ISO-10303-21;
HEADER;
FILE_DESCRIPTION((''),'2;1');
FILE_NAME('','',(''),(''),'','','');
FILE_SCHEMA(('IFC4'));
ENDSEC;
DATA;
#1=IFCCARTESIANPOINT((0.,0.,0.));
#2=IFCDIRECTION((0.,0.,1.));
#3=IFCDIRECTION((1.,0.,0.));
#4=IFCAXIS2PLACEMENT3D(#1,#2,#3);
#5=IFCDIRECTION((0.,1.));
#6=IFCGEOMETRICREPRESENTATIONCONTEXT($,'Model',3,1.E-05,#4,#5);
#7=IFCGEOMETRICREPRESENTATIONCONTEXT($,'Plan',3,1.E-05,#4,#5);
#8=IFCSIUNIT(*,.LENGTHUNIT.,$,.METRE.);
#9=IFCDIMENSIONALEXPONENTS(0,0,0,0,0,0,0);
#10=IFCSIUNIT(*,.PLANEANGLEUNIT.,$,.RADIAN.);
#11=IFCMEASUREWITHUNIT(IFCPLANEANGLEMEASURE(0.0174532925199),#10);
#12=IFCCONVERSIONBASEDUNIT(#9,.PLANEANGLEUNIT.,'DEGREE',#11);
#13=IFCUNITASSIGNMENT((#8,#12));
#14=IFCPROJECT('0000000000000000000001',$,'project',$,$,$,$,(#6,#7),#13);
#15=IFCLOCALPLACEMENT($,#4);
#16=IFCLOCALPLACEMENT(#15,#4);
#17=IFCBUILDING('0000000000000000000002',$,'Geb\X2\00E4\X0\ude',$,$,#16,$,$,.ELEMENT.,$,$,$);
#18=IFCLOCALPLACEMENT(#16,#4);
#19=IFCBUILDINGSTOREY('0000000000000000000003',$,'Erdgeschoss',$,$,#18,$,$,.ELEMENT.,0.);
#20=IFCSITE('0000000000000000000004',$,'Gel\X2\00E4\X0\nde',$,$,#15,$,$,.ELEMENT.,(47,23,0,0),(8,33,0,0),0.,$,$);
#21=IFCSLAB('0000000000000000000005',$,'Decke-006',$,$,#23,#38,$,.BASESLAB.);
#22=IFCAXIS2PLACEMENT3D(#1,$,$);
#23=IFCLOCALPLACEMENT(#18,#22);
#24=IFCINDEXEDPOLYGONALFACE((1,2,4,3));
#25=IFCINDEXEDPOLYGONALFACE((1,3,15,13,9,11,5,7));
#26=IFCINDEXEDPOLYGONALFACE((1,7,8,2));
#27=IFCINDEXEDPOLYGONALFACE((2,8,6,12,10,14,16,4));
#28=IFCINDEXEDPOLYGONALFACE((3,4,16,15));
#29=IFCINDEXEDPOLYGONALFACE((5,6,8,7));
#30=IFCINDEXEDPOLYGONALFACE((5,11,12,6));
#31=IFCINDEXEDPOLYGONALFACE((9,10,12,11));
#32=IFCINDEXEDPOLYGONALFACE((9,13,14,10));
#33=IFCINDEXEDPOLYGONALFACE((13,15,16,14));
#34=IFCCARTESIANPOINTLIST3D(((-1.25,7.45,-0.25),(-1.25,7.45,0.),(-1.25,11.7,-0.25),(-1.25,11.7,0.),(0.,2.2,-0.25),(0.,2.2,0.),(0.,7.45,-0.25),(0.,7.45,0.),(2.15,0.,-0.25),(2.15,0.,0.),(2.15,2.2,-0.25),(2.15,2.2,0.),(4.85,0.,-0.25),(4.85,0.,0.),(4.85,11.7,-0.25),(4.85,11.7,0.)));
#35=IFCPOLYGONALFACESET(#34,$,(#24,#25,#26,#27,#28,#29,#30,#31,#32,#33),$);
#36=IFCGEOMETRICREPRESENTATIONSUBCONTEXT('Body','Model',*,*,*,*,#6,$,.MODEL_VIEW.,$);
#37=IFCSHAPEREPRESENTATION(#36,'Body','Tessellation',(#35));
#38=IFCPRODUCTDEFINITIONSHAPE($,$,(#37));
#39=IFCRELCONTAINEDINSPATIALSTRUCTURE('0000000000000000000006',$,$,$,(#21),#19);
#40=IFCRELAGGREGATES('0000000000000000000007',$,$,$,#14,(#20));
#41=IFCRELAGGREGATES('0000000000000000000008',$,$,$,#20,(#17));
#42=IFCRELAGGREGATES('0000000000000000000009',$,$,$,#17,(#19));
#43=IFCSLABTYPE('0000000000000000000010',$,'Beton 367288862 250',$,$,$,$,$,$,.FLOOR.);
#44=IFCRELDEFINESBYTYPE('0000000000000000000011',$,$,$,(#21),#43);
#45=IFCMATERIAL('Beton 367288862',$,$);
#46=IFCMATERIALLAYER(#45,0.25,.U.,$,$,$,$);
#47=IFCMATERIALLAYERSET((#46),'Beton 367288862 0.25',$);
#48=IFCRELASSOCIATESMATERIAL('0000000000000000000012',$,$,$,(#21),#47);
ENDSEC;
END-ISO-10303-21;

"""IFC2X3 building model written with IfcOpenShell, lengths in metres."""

from ifc_helpers import new_model, entity, si_unit, converted_unit, direction, frame, origin_with_axes, place, context, subcontext, project, spatial, polyline, outline, extrude, material, layer, layer_set, layer_usage, type_object, element, save


model = new_model("IFC2X3")

# Units and contexts
model_context = context("Model", 3, precision=1e-05, world=origin_with_axes(), true_north=direction((0.0, 1.0)))
plan_context = context("Plan", 3, precision=1e-05, world=origin_with_axes(), true_north=direction((0.0, 1.0)))
body_context = subcontext(model_context, "Body", "Model", "MODEL_VIEW")
ifc_project = project(units=[si_unit("LENGTHUNIT", "METRE"), converted_unit("PLANEANGLEUNIT", "DEGREE", entity("IfcPlaneAngleMeasure", 0.0174532925199), si_unit("PLANEANGLEUNIT", "RADIAN"), dimensions=[0, 0, 0, 0, 0, 0, 0])], contexts=[model_context, plan_context])

# Site, building, storey
site_placement = place(None, origin_with_axes())
site = spatial("IfcSite", under=ifc_project, at=site_placement, Name="Gelände", CompositionType="ELEMENT", RefLatitude=(47, 23, 0, 0), RefLongitude=(8, 33, 0, 0), RefElevation=0.0)
building_placement = place(site_placement, origin_with_axes())
building = spatial("IfcBuilding", under=site, at=building_placement, Name="Gebäude", CompositionType="ELEMENT")
storey_placement = place(building_placement, origin_with_axes())
storey = spatial("IfcBuildingStorey", under=building, at=storey_placement, Name="Erdgeschoss", CompositionType="ELEMENT", Elevation=0.0)

# Slab
ifc_material_1 = material(Name="Beton 367288862")
ifc_layer_1 = layer(ifc_material_1, 0.25, ventilated="UNKNOWN")
ifc_layer_set_1 = layer_set([ifc_layer_1], Name="Beton 367288862 0.25")
ifc_layer_usage_1 = layer_usage(ifc_layer_set_1, "AXIS3", "NEGATIVE", 0.25)
slab_type_1 = type_object("IfcSlabType", Name="Beton 367288862 250", PredefinedType="FLOOR")
slab_1_placement = place(storey_placement, frame((-1.25, 11.7, 0.0), z_axis=(0.0, 0.0, 1.0), x_axis=(1.0, 0.0, 0.0)))
element("IfcSlab", 1, at=slab_1_placement, inside=storey, type_object=slab_type_1, material=ifc_layer_usage_1, Name="Decke-006", PredefinedType="BASESLAB", context=body_context, shape_type="SweptSolid", body=[
    extrude(outline(polyline([(0.0, 0.0), (0.0, -4.25), (1.25, -4.25), (1.25, -9.5), (3.4, -9.5), (3.4, -11.7), (6.1, -11.7), (6.1, 0.0), (0.0, 0.0)])), frame((0.0, 0.0, -0.25), z_axis=(0.0, 0.0, 1.0), x_axis=(1.0, 0.0, 0.0)), (0.0, 0.0, 1.0), 0.25),
])

save(model, "model.ifc")
